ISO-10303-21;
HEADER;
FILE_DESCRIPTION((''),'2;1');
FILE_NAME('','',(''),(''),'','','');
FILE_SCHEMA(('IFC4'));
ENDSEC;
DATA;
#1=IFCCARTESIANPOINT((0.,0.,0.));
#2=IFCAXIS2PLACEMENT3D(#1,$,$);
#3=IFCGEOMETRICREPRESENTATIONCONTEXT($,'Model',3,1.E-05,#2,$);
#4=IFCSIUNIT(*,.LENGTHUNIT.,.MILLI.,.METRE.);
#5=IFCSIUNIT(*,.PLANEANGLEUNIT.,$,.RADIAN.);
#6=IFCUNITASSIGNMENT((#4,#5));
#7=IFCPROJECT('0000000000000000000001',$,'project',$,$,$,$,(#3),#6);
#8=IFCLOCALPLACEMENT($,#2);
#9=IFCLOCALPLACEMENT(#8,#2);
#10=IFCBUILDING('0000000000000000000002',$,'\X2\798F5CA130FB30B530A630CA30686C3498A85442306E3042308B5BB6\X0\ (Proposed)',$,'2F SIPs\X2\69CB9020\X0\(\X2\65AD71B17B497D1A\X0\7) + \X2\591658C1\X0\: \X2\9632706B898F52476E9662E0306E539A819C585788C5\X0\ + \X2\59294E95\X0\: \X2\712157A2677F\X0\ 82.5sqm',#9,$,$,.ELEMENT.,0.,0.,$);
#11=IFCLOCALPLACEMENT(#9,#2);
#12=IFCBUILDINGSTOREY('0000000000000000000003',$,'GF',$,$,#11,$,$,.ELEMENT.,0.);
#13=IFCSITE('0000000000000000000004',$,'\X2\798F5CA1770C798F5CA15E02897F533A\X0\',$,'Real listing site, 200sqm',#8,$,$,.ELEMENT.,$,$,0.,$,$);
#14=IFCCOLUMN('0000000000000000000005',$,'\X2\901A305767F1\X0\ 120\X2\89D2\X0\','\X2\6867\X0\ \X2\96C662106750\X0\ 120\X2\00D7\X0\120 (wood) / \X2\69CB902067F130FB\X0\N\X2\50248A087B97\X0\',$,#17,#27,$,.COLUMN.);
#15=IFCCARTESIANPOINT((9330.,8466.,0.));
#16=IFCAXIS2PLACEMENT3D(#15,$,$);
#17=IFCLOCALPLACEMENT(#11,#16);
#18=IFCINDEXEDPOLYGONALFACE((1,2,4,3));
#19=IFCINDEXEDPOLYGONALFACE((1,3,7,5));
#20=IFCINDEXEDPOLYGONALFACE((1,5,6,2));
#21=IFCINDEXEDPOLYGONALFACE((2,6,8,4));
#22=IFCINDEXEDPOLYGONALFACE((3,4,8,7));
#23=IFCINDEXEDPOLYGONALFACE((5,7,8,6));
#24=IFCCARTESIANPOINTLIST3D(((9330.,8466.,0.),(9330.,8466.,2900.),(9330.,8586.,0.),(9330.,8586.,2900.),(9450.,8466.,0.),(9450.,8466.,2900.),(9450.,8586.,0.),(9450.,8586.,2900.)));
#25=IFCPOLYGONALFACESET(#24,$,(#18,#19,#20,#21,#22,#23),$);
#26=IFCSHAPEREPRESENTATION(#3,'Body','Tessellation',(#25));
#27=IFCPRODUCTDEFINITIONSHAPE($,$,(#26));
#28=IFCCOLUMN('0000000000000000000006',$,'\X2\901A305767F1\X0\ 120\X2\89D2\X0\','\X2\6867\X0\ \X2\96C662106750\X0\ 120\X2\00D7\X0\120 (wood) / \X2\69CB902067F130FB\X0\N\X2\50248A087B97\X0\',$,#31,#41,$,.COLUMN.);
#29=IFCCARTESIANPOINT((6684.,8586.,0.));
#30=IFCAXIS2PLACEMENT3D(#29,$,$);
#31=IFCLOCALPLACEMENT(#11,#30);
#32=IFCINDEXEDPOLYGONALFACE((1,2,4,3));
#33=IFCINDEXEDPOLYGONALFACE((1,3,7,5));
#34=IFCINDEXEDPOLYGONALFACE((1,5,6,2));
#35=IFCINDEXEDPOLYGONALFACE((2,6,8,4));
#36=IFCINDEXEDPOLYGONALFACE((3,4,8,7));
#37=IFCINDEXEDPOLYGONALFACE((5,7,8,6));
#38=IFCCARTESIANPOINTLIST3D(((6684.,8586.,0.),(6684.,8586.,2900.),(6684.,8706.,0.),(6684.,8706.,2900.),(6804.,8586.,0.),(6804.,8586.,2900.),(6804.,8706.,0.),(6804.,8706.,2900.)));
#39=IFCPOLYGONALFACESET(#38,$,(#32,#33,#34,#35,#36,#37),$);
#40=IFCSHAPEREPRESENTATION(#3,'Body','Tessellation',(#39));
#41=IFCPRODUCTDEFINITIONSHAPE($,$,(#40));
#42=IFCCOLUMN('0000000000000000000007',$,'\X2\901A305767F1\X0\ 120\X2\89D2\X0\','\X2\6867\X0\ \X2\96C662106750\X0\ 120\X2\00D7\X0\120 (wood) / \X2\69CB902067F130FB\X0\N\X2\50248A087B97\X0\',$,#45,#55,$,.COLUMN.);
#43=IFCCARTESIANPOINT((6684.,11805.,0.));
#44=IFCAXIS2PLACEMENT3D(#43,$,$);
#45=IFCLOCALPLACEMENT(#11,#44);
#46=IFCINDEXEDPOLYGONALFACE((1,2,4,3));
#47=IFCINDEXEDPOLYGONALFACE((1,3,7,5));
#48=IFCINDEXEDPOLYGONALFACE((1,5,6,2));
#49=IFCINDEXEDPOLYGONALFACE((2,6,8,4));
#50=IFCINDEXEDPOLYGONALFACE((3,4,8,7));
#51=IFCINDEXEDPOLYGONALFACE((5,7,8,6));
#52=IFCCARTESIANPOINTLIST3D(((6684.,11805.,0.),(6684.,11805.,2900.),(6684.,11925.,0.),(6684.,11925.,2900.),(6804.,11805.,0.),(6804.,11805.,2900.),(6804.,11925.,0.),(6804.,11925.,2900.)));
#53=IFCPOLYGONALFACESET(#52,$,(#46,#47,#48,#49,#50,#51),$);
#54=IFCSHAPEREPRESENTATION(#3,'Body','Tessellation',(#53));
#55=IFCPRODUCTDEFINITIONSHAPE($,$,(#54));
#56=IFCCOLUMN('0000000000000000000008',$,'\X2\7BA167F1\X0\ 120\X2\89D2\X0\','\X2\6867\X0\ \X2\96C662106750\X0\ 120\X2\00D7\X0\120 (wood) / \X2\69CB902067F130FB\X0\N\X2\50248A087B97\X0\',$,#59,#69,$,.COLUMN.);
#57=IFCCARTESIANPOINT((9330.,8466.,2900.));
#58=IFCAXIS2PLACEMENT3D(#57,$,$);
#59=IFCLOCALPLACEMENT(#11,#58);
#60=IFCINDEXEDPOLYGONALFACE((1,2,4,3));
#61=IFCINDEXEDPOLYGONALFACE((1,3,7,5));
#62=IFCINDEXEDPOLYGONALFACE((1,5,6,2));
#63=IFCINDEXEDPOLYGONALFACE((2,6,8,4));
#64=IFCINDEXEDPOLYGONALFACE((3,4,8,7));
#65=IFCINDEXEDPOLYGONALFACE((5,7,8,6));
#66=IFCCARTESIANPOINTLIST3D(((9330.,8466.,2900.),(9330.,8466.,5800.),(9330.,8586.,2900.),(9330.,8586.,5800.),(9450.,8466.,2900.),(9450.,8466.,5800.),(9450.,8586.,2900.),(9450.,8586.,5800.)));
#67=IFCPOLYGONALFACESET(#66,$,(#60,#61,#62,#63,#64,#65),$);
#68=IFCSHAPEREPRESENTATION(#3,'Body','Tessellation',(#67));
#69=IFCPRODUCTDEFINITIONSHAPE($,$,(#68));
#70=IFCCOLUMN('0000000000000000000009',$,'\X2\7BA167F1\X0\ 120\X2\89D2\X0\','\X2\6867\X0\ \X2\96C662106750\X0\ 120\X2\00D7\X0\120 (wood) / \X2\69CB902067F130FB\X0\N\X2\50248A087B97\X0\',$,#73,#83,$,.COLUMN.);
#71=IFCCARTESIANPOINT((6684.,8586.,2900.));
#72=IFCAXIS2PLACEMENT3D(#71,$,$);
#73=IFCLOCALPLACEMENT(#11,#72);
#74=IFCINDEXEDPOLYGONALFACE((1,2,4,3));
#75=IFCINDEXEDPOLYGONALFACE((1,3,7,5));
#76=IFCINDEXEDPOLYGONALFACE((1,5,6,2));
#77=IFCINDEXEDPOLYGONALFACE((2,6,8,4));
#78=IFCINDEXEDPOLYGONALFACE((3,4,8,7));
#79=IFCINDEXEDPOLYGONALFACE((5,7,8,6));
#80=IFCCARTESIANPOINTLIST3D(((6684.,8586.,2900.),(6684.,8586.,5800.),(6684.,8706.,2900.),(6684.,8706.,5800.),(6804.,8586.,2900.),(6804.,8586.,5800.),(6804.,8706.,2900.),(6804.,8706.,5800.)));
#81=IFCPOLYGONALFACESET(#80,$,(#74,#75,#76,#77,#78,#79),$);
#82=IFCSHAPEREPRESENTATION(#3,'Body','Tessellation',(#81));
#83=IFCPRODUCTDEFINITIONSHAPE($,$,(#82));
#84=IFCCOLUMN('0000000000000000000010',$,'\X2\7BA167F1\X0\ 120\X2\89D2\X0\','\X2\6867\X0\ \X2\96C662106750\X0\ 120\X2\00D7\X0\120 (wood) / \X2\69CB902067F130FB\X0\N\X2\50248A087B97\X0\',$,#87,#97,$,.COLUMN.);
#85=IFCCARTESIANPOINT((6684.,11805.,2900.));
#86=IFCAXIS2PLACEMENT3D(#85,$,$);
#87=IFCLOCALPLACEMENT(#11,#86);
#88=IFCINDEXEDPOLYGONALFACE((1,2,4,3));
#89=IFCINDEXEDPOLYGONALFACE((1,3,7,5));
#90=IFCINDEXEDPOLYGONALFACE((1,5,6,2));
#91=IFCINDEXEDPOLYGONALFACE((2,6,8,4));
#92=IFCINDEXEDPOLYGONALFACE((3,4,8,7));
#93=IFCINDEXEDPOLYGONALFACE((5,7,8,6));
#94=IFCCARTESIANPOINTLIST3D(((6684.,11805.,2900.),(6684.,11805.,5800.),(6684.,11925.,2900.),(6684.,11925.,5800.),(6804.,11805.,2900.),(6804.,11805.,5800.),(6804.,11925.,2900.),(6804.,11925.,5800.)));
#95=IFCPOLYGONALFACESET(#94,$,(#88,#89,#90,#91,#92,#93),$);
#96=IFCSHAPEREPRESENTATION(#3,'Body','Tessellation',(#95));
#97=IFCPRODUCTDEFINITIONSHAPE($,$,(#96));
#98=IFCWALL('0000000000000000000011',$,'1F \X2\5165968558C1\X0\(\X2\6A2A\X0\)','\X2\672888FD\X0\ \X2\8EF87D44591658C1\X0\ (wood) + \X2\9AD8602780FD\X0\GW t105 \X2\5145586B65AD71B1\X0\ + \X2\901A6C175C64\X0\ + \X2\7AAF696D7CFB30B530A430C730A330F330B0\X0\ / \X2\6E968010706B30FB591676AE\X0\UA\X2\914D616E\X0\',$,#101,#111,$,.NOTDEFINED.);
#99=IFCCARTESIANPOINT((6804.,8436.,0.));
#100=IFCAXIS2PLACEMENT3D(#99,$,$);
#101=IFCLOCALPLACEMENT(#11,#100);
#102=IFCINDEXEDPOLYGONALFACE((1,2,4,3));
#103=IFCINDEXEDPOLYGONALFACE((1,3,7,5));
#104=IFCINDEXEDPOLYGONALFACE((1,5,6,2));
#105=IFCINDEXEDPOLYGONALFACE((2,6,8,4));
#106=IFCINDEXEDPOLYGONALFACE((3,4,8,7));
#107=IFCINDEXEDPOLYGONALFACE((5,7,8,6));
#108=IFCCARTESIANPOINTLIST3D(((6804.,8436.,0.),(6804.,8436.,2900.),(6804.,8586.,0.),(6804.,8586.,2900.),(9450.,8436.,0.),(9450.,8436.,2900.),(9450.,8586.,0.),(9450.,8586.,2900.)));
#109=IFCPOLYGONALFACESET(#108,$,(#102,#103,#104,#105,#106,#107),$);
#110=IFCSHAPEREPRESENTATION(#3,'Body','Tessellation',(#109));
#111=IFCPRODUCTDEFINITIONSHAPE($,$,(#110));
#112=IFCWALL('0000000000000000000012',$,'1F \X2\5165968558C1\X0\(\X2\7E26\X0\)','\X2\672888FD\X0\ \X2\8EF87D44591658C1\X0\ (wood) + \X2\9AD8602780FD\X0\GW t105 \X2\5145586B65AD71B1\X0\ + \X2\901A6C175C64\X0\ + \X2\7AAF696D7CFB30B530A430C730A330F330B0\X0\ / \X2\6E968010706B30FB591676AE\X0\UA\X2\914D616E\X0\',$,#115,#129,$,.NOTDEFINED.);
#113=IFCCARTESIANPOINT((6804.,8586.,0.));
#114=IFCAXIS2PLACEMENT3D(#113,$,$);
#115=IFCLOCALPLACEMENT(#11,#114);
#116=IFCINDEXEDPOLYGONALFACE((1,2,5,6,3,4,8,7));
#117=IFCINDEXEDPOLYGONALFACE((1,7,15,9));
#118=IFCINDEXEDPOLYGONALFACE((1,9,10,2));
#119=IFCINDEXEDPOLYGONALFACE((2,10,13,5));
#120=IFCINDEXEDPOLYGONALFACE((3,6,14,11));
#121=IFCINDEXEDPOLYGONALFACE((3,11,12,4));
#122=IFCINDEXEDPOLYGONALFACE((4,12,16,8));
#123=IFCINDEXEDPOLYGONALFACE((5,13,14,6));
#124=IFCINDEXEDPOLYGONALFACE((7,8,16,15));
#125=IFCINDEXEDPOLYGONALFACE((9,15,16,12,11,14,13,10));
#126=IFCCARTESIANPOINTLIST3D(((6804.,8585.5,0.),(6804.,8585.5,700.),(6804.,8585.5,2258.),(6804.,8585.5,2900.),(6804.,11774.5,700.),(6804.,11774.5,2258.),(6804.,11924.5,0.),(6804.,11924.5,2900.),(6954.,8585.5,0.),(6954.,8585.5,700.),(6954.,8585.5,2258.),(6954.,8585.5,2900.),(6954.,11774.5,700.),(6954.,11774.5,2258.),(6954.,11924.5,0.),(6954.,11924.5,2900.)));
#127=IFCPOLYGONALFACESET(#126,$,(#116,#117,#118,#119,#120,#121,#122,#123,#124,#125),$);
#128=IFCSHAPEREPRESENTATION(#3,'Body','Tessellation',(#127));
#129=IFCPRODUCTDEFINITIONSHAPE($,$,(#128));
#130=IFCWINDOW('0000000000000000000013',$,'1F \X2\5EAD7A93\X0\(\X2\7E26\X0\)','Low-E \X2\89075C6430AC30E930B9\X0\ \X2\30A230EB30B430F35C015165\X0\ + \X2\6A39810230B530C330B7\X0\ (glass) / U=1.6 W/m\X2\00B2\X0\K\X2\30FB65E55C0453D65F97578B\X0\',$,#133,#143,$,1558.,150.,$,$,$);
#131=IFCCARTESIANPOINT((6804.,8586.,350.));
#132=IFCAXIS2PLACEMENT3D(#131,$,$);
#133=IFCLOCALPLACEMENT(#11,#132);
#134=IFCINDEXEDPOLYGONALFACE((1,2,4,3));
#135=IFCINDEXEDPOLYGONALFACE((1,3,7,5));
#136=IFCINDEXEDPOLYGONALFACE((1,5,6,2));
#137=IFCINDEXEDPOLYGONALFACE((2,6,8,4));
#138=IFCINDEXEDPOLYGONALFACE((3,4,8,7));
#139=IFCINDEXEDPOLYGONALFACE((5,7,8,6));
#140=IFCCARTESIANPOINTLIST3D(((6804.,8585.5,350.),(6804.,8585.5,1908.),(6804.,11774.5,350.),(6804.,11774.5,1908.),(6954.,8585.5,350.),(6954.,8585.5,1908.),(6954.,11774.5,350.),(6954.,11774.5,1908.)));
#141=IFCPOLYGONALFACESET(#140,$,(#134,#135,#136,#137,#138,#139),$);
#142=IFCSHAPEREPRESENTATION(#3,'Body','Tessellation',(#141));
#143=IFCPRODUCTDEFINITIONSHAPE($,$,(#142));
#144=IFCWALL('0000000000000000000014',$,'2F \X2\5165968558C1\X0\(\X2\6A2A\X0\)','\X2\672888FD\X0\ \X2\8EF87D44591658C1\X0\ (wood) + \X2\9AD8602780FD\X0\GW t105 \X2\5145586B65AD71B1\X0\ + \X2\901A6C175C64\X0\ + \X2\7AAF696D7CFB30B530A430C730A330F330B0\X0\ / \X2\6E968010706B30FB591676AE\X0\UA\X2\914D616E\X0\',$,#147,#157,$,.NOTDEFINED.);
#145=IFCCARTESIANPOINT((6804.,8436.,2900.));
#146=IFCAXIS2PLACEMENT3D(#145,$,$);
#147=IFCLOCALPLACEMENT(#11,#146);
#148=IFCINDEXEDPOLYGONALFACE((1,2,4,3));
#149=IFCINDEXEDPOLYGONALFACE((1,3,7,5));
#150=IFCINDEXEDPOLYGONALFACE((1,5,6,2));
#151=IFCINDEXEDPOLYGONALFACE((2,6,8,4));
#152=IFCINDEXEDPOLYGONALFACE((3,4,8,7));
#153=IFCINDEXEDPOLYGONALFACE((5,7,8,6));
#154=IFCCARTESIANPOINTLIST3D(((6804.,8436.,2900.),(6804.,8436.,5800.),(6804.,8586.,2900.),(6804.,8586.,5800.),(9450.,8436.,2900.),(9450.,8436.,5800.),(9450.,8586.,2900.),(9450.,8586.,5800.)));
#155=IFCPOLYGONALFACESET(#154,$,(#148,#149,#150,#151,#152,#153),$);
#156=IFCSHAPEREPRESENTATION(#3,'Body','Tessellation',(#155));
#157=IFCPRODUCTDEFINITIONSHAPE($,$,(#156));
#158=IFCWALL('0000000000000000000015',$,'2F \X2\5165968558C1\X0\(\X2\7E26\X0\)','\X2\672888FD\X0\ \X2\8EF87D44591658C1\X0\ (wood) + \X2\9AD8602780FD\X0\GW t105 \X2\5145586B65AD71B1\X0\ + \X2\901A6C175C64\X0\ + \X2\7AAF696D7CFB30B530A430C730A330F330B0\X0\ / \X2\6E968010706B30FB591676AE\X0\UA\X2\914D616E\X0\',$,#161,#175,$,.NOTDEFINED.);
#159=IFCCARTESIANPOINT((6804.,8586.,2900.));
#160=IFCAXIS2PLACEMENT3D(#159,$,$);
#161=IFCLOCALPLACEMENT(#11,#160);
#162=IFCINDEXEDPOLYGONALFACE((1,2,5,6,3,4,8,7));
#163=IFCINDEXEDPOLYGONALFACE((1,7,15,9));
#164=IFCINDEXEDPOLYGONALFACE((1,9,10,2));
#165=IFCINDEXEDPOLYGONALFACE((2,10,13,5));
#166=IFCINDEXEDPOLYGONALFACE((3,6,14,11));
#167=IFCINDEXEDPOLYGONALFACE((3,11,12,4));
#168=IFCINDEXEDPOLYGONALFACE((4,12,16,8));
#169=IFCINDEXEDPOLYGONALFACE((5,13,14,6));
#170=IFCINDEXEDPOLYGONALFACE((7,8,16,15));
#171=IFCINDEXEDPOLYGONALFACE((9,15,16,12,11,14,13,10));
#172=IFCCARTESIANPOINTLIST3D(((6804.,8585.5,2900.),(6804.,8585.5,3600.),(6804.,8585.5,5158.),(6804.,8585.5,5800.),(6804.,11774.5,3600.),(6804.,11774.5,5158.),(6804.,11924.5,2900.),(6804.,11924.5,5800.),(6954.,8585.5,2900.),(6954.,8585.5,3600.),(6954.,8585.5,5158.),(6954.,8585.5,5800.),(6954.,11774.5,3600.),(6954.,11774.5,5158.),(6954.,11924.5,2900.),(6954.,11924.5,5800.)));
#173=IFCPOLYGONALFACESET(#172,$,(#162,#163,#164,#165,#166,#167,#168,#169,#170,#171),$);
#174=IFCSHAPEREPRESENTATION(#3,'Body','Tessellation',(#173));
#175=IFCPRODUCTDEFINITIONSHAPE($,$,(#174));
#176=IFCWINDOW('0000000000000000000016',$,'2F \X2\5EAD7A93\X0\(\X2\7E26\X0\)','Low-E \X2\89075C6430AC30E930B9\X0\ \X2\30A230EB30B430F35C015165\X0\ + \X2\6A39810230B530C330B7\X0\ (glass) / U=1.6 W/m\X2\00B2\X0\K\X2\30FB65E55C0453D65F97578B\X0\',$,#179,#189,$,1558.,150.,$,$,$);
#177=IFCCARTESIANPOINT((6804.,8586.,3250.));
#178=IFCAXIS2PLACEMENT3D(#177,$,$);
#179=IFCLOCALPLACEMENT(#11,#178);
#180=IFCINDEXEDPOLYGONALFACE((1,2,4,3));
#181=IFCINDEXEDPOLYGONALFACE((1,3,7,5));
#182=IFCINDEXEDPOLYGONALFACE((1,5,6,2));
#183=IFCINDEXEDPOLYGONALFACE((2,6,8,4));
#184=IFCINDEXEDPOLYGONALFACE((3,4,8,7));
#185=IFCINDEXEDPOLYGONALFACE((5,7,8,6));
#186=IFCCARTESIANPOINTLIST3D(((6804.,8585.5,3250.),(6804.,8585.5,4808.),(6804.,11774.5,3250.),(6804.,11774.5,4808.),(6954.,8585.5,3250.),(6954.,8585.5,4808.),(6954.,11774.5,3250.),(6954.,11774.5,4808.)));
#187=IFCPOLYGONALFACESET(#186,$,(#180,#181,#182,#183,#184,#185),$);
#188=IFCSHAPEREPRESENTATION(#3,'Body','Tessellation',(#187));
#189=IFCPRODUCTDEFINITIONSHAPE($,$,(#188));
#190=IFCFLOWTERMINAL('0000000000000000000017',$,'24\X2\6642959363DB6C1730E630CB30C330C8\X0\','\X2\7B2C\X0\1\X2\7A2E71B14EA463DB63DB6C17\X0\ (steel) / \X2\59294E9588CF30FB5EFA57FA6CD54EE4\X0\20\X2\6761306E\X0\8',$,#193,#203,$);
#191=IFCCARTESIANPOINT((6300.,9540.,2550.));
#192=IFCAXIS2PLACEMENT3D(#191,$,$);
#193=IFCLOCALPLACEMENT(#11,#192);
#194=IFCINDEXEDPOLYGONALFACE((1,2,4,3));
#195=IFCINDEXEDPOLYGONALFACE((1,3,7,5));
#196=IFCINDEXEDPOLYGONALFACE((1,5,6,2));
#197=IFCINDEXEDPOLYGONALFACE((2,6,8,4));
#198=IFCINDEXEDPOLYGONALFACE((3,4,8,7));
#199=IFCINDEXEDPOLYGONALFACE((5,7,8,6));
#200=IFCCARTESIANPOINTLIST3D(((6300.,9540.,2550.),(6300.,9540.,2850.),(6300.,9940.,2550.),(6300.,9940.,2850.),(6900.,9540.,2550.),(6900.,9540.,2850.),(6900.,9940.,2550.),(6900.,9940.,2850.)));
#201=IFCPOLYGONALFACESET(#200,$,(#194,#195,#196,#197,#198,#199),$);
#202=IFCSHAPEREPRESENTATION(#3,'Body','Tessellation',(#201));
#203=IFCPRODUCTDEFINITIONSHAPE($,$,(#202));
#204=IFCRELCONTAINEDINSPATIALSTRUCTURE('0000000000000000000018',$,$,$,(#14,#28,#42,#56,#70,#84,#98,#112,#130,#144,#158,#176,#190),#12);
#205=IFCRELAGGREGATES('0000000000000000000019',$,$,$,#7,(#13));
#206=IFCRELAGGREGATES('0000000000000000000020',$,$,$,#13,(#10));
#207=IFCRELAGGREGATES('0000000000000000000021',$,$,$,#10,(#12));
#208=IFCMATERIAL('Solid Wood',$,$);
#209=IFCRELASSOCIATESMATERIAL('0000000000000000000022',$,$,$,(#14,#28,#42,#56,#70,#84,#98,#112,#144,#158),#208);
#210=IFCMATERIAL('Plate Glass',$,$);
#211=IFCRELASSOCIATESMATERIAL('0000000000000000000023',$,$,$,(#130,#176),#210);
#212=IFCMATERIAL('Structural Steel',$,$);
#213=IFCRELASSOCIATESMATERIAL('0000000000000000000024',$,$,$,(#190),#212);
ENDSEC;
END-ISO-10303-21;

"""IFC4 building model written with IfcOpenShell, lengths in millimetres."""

from ifc_helpers import new_model, si_unit, frame, frame_2d, origin, place, context, project, spatial, rectangle, extrude, material, element, fill, save


model = new_model("IFC4")

# Units and contexts
model_context = context("Model", 3, precision=1e-05, world=origin())
ifc_project = project(units=[si_unit("LENGTHUNIT", "METRE", prefix="MILLI"), si_unit("PLANEANGLEUNIT", "RADIAN")], contexts=[model_context])

# Site, building, storey
site_placement = place(None, origin())
site = spatial("IfcSite", under=ifc_project, at=site_placement, Name="福岡県福岡市西区", ObjectType="Real listing site, 200sqm", CompositionType="ELEMENT", RefElevation=0.0)
building_placement = place(site_placement, origin())
building = spatial("IfcBuilding", under=site, at=building_placement, Name="福岡・サウナと水風呂のある家 (Proposed)", ObjectType="2F SIPs構造(断熱等級7) + 外壁: 防火規則準拠の厚膜塗装 + 天井: 無垢板 82.5sqm", CompositionType="ELEMENT", ElevationOfRefHeight=0.0, ElevationOfTerrain=0.0)
storey_placement = place(building_placement, origin())
storey = spatial("IfcBuildingStorey", under=building, at=storey_placement, Name="GF", CompositionType="ELEMENT", Elevation=0.0)

# Columns
ifc_material_1 = material(Name="Solid Wood")
column_1_placement = place(storey_placement, frame((9330.0, 8466.0, 0.0)))
element("IfcColumn", 1, at=column_1_placement, inside=storey, material=ifc_material_1, Name="通し柱 120角", Description="桧 集成材 120×120 (wood) / 構造柱・N値計算", PredefinedType="COLUMN", context=model_context, shape_type="SweptSolid", body=[
    extrude(rectangle(XDim=120.0, YDim=120.0, at=frame_2d((60.0, 60.0))), frame((9330.0, 8466.0, 0.0)), (0.0, 0.0, 1.0), 2900.0),
])
column_2_placement = place(storey_placement, frame((6684.0, 8586.0, 0.0)))
element("IfcColumn", 2, at=column_2_placement, inside=storey, material=ifc_material_1, Name="通し柱 120角", Description="桧 集成材 120×120 (wood) / 構造柱・N値計算", PredefinedType="COLUMN", context=model_context, shape_type="SweptSolid", body=[
    extrude(rectangle(XDim=120.0, YDim=120.0, at=frame_2d((60.0, 60.0))), frame((6684.0, 8586.0, 0.0)), (0.0, 0.0, 1.0), 2900.0),
])
column_3_placement = place(storey_placement, frame((6684.0, 11805.0, 0.0)))
element("IfcColumn", 3, at=column_3_placement, inside=storey, material=ifc_material_1, Name="通し柱 120角", Description="桧 集成材 120×120 (wood) / 構造柱・N値計算", PredefinedType="COLUMN", context=model_context, shape_type="SweptSolid", body=[
    extrude(rectangle(XDim=120.0, YDim=120.0, at=frame_2d((60.0, 60.0))), frame((6684.0, 11805.0, 0.0)), (0.0, 0.0, 1.0), 2900.0),
])
column_4_placement = place(storey_placement, frame((9330.0, 8466.0, 2900.0)))
element("IfcColumn", 4, at=column_4_placement, inside=storey, material=ifc_material_1, Name="管柱 120角", Description="桧 集成材 120×120 (wood) / 構造柱・N値計算", PredefinedType="COLUMN", context=model_context, shape_type="SweptSolid", body=[
    extrude(rectangle(XDim=120.0, YDim=120.0, at=frame_2d((60.0, 60.0))), frame((9330.0, 8466.0, 2900.0)), (0.0, 0.0, 1.0), 2900.0),
])
column_5_placement = place(storey_placement, frame((6684.0, 8586.0, 2900.0)))
element("IfcColumn", 5, at=column_5_placement, inside=storey, material=ifc_material_1, Name="管柱 120角", Description="桧 集成材 120×120 (wood) / 構造柱・N値計算", PredefinedType="COLUMN", context=model_context, shape_type="SweptSolid", body=[
    extrude(rectangle(XDim=120.0, YDim=120.0, at=frame_2d((60.0, 60.0))), frame((6684.0, 8586.0, 2900.0)), (0.0, 0.0, 1.0), 2900.0),
])
column_6_placement = place(storey_placement, frame((6684.0, 11805.0, 2900.0)))
element("IfcColumn", 6, at=column_6_placement, inside=storey, material=ifc_material_1, Name="管柱 120角", Description="桧 集成材 120×120 (wood) / 構造柱・N値計算", PredefinedType="COLUMN", context=model_context, shape_type="SweptSolid", body=[
    extrude(rectangle(XDim=120.0, YDim=120.0, at=frame_2d((60.0, 60.0))), frame((6684.0, 11805.0, 2900.0)), (0.0, 0.0, 1.0), 2900.0),
])

# Wall
wall_1_placement = place(storey_placement, frame((6804.0, 8436.0, 0.0)))
element("IfcWall", 7, at=wall_1_placement, inside=storey, material=ifc_material_1, Name="1F 入隅壁(横)", Description="木製 軸組外壁 (wood) + 高性能GW t105 充填断熱 + 通気層 + 窯業系サイディング / 準耐火・外皮UA配慮", PredefinedType="NOTDEFINED", context=model_context, shape_type="SweptSolid", body=[
    extrude(rectangle(XDim=2646.0, YDim=150.0, at=frame_2d((1323.0, 75.0))), frame((6804.0, 8436.0, 0.0)), (0.0, 0.0, 1.0), 2900.0),
])

# Wall, opening, window
wall_2_placement = place(storey_placement, frame((6804.0, 8586.0, 0.0)))
wall_2 = element("IfcWall", 8, at=wall_2_placement, inside=storey, material=ifc_material_1, Name="1F 入隅壁(縦)", Description="木製 軸組外壁 (wood) + 高性能GW t105 充填断熱 + 通気層 + 窯業系サイディング / 準耐火・外皮UA配慮", PredefinedType="NOTDEFINED", context=model_context, shape_type="SweptSolid", body=[
    extrude(rectangle(XDim=150.0, YDim=3339.0, at=frame_2d((75.0, 1669.0))), frame((6804.0, 8586.0, 0.0)), (0.0, 0.0, 1.0), 2900.0),
])
opening_1_placement = place(storey_placement, frame((6804.0, 8586.0, 350.0)))
opening_1 = element("IfcOpeningElement", 9, at=opening_1_placement, cuts=wall_2, PredefinedType="NOTDEFINED", context=model_context, shape_type="SweptSolid", body=[
    extrude(rectangle(XDim=150.0, YDim=3189.0, at=frame_2d((75.0, 1594.0))), frame((6804.0, 8586.0, 350.0)), (0.0, 0.0, 1.0), 1558.0),
])
ifc_material_2 = material(Name="Plate Glass")
window_1_placement = place(storey_placement, frame((6804.0, 8586.0, 350.0)))
window_1 = element("IfcWindow", 10, at=window_1_placement, inside=storey, material=ifc_material_2, Name="1F 庭窓(縦)", Description="Low-E 複層ガラス アルゴン封入 + 樹脂サッシ (glass) / U=1.6 W/m²K・日射取得型", OverallHeight=1558.0, OverallWidth=150.0, context=model_context, shape_type="SweptSolid", body=[
    extrude(rectangle(XDim=150.0, YDim=3189.0, at=frame_2d((75.0, 1594.0))), frame((6804.0, 8586.0, 350.0)), (0.0, 0.0, 1.0), 1558.0),
])
fill(opening_1, window_1)

# Wall
wall_3_placement = place(storey_placement, frame((6804.0, 8436.0, 2900.0)))
element("IfcWall", 11, at=wall_3_placement, inside=storey, material=ifc_material_1, Name="2F 入隅壁(横)", Description="木製 軸組外壁 (wood) + 高性能GW t105 充填断熱 + 通気層 + 窯業系サイディング / 準耐火・外皮UA配慮", PredefinedType="NOTDEFINED", context=model_context, shape_type="SweptSolid", body=[
    extrude(rectangle(XDim=2646.0, YDim=150.0, at=frame_2d((1323.0, 75.0))), frame((6804.0, 8436.0, 2900.0)), (0.0, 0.0, 1.0), 2900.0),
])

# Wall, opening, window
wall_4_placement = place(storey_placement, frame((6804.0, 8586.0, 2900.0)))
wall_4 = element("IfcWall", 12, at=wall_4_placement, inside=storey, material=ifc_material_1, Name="2F 入隅壁(縦)", Description="木製 軸組外壁 (wood) + 高性能GW t105 充填断熱 + 通気層 + 窯業系サイディング / 準耐火・外皮UA配慮", PredefinedType="NOTDEFINED", context=model_context, shape_type="SweptSolid", body=[
    extrude(rectangle(XDim=150.0, YDim=3339.0, at=frame_2d((75.0, 1669.0))), frame((6804.0, 8586.0, 2900.0)), (0.0, 0.0, 1.0), 2900.0),
])
opening_2_placement = place(storey_placement, frame((6804.0, 8586.0, 3250.0)))
opening_2 = element("IfcOpeningElement", 13, at=opening_2_placement, cuts=wall_4, PredefinedType="NOTDEFINED", context=model_context, shape_type="SweptSolid", body=[
    extrude(rectangle(XDim=150.0, YDim=3189.0, at=frame_2d((75.0, 1594.0))), frame((6804.0, 8586.0, 3250.0)), (0.0, 0.0, 1.0), 1558.0),
])
window_2_placement = place(storey_placement, frame((6804.0, 8586.0, 3250.0)))
window_2 = element("IfcWindow", 14, at=window_2_placement, inside=storey, material=ifc_material_2, Name="2F 庭窓(縦)", Description="Low-E 複層ガラス アルゴン封入 + 樹脂サッシ (glass) / U=1.6 W/m²K・日射取得型", OverallHeight=1558.0, OverallWidth=150.0, context=model_context, shape_type="SweptSolid", body=[
    extrude(rectangle(XDim=150.0, YDim=3189.0, at=frame_2d((75.0, 1594.0))), frame((6804.0, 8586.0, 3250.0)), (0.0, 0.0, 1.0), 1558.0),
])
fill(opening_2, window_2)

# Flow terminal
ifc_material_3 = material(Name="Structural Steel")
flow_terminal_placement = place(storey_placement, frame((6300.0, 9540.0, 2550.0)))
element("IfcFlowTerminal", 15, at=flow_terminal_placement, inside=storey, material=ifc_material_3, Name="24時間換気ユニット", Description="第1種熱交換換気 (steel) / 天井裏・建基法令20条の8", context=model_context, shape_type="SweptSolid", body=[
    extrude(rectangle(XDim=600.0, YDim=400.0, at=frame_2d((300.0, 200.0))), frame((6300.0, 9540.0, 2550.0)), (0.0, 0.0, 1.0), 300.0),
])

save(model, "model.ifc")
